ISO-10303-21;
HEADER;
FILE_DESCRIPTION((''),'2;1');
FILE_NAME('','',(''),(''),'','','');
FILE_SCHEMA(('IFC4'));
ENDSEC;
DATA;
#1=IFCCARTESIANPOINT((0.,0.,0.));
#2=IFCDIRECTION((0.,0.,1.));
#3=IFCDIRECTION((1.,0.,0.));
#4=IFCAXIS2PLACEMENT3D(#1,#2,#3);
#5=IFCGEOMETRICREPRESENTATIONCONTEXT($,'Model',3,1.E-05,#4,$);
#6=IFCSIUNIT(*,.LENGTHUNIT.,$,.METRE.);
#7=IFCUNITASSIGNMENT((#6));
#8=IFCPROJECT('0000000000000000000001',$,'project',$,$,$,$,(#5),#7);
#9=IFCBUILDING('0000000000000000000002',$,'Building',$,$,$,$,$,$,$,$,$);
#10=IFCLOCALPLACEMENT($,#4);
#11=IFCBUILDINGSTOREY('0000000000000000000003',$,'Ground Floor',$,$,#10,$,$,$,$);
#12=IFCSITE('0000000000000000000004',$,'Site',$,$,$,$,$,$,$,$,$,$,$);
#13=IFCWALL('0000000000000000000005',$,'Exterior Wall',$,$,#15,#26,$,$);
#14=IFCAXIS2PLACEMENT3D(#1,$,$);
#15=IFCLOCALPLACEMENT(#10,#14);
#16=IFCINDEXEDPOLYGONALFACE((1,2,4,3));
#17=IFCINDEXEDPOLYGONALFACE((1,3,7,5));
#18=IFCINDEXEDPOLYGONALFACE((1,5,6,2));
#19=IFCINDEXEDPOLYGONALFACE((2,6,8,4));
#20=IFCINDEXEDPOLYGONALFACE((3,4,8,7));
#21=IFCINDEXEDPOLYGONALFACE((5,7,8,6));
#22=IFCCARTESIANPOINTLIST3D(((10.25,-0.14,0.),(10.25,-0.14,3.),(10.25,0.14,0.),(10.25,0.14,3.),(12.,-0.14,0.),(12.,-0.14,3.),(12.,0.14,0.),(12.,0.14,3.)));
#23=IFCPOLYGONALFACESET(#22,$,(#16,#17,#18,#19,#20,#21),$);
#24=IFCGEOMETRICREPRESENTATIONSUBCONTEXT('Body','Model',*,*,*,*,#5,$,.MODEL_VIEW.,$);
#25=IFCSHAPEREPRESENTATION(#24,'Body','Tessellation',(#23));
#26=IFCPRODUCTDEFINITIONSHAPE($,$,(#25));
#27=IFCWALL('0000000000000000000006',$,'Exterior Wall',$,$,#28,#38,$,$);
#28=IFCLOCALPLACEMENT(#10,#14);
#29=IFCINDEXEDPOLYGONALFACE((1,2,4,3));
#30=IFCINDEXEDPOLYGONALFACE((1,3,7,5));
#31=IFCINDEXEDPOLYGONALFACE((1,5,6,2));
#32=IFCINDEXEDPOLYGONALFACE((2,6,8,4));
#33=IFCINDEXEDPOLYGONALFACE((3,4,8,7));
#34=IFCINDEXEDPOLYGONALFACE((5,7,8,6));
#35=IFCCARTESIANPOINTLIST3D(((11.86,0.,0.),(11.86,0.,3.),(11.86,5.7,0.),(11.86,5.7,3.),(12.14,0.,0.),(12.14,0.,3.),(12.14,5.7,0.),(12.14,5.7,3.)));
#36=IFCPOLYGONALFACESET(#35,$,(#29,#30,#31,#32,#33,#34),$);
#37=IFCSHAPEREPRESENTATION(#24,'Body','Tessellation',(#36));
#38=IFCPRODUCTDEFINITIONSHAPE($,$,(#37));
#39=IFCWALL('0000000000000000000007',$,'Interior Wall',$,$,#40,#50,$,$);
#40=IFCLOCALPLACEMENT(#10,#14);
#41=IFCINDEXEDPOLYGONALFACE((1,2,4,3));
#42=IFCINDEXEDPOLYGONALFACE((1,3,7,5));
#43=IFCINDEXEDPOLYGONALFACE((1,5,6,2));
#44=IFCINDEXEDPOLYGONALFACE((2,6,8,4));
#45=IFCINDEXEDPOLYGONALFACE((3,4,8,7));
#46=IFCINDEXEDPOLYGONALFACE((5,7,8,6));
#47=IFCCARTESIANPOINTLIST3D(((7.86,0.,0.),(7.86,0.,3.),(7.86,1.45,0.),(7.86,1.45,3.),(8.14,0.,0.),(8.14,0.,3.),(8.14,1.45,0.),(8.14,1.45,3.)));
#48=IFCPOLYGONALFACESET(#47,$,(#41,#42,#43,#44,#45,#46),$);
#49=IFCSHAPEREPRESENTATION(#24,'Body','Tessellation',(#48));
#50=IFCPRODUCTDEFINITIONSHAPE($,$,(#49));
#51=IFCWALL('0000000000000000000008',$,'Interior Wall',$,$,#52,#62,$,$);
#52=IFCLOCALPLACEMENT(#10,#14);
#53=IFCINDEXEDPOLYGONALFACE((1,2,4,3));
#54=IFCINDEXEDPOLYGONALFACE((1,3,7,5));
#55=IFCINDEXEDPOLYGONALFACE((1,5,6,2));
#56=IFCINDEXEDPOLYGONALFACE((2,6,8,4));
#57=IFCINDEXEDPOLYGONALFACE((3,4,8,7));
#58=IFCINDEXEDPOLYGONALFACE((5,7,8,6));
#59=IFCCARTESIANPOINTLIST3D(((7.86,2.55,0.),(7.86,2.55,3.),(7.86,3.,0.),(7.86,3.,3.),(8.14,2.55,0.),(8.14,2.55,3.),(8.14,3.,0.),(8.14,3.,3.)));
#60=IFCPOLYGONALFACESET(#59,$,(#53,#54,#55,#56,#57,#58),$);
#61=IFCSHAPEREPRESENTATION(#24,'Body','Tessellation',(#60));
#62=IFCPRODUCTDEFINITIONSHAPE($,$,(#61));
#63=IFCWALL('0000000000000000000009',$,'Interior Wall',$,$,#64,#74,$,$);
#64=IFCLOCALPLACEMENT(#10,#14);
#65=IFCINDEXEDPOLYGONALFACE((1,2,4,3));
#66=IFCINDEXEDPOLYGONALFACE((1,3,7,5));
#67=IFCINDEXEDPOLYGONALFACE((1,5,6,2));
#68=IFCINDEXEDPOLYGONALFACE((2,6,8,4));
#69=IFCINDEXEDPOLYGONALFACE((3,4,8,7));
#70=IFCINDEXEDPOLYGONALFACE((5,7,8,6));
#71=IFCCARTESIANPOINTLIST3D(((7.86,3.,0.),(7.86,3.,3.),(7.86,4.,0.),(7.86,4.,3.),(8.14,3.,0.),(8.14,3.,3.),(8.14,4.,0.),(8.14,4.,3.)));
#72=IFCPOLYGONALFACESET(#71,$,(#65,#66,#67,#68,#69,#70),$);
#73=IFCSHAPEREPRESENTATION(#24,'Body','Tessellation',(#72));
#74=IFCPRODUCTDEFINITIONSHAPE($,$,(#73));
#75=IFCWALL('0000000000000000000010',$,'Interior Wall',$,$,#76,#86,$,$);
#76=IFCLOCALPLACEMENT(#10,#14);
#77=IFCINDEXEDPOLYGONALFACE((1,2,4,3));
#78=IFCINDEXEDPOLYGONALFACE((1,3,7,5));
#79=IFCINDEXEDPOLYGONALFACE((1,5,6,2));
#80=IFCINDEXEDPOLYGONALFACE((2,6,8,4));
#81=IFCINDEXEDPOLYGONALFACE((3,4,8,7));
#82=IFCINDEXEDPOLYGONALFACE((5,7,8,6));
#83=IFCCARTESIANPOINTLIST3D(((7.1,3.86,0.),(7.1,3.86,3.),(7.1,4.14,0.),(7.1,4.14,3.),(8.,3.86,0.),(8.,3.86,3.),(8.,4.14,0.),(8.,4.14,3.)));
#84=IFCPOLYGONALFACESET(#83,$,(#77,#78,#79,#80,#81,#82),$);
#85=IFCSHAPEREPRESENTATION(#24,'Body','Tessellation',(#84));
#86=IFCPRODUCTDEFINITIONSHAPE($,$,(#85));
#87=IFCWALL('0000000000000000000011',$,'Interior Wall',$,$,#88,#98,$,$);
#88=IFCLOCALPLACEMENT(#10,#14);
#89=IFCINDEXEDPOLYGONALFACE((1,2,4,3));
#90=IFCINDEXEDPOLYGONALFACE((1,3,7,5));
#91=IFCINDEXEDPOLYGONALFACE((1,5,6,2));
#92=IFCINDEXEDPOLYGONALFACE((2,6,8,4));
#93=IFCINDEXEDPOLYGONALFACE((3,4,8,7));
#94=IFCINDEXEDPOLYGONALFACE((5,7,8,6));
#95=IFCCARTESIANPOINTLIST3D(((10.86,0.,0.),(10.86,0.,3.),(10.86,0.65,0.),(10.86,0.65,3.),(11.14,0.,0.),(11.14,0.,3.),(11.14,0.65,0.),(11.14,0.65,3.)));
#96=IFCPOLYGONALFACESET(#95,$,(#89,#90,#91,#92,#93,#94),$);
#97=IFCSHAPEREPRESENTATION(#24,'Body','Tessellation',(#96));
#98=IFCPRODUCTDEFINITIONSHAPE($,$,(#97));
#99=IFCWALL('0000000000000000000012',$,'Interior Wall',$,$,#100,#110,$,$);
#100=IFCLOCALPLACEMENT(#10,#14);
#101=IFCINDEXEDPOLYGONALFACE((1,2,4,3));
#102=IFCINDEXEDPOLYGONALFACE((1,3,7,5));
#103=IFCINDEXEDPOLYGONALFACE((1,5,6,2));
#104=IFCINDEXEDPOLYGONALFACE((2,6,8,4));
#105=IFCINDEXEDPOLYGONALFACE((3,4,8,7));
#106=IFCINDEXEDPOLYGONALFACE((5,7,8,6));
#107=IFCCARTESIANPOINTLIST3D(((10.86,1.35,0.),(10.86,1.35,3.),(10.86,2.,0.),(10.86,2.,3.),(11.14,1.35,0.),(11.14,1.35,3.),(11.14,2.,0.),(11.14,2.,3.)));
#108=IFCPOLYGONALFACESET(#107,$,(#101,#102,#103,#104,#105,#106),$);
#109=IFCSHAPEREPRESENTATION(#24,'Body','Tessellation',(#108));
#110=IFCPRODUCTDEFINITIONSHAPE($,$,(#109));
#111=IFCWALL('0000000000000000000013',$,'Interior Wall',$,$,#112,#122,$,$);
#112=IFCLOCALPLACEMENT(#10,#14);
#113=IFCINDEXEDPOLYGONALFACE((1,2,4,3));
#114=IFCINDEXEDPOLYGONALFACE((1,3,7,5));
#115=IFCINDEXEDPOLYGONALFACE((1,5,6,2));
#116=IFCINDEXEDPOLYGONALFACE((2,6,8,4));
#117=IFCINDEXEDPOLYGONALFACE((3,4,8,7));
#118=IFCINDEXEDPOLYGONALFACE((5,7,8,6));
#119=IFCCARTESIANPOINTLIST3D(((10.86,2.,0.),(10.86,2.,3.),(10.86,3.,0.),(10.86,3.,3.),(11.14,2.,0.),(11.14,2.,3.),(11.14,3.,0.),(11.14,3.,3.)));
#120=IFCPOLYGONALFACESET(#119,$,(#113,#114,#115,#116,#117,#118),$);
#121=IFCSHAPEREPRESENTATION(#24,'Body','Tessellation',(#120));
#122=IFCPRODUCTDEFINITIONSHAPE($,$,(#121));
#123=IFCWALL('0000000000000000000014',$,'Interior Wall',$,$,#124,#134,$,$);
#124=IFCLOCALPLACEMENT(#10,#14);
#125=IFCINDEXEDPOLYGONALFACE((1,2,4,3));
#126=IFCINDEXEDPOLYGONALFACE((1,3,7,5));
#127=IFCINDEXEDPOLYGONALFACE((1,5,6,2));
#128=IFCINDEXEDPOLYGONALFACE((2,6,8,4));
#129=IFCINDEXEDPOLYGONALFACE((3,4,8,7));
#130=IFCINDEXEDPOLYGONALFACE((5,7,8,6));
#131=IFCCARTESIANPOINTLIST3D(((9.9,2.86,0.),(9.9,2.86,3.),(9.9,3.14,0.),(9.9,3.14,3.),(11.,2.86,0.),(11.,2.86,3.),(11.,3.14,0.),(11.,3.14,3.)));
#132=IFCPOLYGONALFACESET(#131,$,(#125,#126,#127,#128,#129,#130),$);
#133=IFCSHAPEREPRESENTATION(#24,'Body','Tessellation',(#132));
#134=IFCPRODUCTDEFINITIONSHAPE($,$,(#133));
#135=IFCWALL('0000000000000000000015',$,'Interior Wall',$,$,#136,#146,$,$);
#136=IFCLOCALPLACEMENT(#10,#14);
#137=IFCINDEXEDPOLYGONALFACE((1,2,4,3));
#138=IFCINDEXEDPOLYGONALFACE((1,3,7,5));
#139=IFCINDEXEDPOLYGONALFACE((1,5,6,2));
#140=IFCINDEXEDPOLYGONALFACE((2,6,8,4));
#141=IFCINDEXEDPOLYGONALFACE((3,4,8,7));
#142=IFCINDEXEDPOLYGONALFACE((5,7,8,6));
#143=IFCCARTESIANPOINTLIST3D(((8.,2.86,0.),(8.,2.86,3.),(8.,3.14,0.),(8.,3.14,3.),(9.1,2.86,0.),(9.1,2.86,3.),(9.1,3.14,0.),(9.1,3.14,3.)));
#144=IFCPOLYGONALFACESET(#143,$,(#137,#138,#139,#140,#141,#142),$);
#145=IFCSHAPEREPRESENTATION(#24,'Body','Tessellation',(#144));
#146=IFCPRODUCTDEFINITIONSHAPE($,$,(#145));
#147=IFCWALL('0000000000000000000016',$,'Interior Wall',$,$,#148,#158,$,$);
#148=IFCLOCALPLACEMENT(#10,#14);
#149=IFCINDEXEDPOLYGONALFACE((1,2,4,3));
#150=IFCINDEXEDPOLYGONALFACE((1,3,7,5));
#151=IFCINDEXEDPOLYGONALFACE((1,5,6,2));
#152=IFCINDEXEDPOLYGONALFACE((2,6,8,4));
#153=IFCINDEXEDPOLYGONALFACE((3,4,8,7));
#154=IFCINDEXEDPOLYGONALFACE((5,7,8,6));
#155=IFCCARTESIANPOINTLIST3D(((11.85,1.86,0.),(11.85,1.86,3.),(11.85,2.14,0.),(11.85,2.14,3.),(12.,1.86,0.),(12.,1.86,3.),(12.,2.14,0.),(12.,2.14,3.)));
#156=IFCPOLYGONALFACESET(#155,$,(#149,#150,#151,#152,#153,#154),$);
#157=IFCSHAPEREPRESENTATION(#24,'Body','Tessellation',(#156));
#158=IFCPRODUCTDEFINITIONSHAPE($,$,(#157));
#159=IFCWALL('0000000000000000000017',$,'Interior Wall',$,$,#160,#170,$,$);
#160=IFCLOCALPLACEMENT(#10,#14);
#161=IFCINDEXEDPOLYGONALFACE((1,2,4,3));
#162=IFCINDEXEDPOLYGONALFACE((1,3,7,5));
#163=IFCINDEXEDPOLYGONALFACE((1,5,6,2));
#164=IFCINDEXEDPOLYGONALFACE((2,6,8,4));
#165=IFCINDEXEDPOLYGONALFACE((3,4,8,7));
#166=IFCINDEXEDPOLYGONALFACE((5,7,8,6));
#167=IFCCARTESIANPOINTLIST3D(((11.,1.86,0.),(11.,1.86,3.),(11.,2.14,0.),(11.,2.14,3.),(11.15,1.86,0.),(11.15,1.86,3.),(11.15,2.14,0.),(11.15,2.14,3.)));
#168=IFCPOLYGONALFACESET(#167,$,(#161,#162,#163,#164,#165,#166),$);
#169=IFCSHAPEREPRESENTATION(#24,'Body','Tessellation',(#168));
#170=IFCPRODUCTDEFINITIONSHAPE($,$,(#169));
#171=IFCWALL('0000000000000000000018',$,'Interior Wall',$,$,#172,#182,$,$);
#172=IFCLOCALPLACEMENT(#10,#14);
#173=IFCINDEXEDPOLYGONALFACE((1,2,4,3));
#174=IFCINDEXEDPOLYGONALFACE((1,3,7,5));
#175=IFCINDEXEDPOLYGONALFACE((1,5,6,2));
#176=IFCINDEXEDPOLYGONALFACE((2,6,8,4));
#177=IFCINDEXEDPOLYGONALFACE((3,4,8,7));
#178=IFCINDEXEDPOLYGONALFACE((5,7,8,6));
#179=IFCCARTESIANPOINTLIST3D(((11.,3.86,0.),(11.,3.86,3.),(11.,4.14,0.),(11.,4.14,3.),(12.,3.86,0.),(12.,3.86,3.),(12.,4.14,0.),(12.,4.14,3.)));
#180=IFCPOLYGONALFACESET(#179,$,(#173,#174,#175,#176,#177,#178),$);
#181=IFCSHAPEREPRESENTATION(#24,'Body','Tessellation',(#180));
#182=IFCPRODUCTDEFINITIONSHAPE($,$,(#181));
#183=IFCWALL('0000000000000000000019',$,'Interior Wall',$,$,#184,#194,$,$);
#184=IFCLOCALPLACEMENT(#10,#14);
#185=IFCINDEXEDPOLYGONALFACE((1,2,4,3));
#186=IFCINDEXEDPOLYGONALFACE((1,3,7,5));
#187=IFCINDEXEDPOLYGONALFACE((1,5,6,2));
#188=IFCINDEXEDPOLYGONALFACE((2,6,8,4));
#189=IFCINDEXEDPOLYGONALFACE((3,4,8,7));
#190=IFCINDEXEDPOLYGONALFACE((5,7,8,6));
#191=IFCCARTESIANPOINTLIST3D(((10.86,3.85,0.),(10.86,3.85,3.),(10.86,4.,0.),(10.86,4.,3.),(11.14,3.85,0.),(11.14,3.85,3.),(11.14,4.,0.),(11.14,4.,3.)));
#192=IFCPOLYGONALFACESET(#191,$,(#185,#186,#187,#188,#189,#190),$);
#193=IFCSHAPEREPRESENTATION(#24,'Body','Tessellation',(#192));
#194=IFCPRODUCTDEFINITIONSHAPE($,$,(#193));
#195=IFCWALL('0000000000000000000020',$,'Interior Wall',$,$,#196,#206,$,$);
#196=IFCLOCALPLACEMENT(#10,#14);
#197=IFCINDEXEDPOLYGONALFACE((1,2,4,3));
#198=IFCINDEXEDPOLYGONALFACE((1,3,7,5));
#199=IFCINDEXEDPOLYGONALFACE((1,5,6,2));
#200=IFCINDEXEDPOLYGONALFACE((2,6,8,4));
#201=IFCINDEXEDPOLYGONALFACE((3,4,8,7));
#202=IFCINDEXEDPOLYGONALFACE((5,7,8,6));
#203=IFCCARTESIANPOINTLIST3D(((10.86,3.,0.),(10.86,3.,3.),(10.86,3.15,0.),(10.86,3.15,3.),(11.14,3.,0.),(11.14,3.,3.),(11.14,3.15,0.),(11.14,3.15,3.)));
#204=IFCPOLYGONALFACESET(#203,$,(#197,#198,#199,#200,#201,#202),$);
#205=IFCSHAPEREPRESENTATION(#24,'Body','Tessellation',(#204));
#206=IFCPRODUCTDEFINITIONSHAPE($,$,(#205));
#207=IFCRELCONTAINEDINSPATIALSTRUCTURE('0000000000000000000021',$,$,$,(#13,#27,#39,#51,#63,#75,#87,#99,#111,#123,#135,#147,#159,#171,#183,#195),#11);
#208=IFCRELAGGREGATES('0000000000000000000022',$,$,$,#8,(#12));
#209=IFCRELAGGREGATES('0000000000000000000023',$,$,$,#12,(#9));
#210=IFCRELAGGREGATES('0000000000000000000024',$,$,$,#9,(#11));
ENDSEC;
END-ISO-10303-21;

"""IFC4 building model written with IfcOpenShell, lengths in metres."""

from ifc_helpers import new_model, si_unit, frame, origin_with_axes, place, context, subcontext, project, spatial, indexed_curve, outline, extrude, element, save


model = new_model("IFC4")

# Units and contexts
model_context = context("Model", 3, precision=1e-05, world=origin_with_axes())
body_context = subcontext(model_context, "Body", "Model", "MODEL_VIEW")
ifc_project = project(units=[si_unit("LENGTHUNIT", "METRE")], contexts=[model_context])

# Site, building, storey
site = spatial("IfcSite", under=ifc_project, Name="Site")
building = spatial("IfcBuilding", under=site, Name="Building")
storey_placement = place(None, origin_with_axes())
storey = spatial("IfcBuildingStorey", under=building, at=storey_placement, Name="Ground Floor")

# Walls
wall_1_placement = place(storey_placement, frame((10.25, 0.0, 0.0), z_axis=(0.0, 0.0, 1.0), x_axis=(1.0, 0.0, 0.0)))
element("IfcWall", 1, at=wall_1_placement, inside=storey, Name="Exterior Wall", context=body_context, shape_type="SweptSolid", body=[
    extrude(outline(indexed_curve([(0.0, 0.0), (0.0, 0.28), (1.75, 0.28), (1.75, 0.0), (0.0, 0.0)], self_intersect=False)), frame((0.0, -0.14, 0.0), z_axis=(0.0, 0.0, 1.0), x_axis=(1.0, 0.0, 0.0)), (0.0, 0.0, 1.0), 3.0),
])
wall_2_placement = place(storey_placement, frame((12.0, 0.0, 0.0), z_axis=(0.0, 0.0, 1.0), x_axis=(0.0, 1.0, 0.0)))
element("IfcWall", 2, at=wall_2_placement, inside=storey, Name="Exterior Wall", context=body_context, shape_type="SweptSolid", body=[
    extrude(outline(indexed_curve([(0.0, 0.0), (0.0, 0.28), (5.7, 0.28), (5.7, 0.0), (0.0, 0.0)], self_intersect=False)), frame((0.0, -0.14, 0.0), z_axis=(0.0, 0.0, 1.0), x_axis=(1.0, 0.0, 0.0)), (0.0, 0.0, 1.0), 3.0),
])
wall_3_placement = place(storey_placement, frame((8.0, 0.0, 0.0), z_axis=(0.0, 0.0, 1.0), x_axis=(0.0, 1.0, 0.0)))
element("IfcWall", 3, at=wall_3_placement, inside=storey, Name="Interior Wall", context=body_context, shape_type="SweptSolid", body=[
    extrude(outline(indexed_curve([(0.0, 0.0), (0.0, 0.28), (1.45, 0.28), (1.45, 0.0), (0.0, 0.0)], self_intersect=False)), frame((0.0, -0.14, 0.0), z_axis=(0.0, 0.0, 1.0), x_axis=(1.0, 0.0, 0.0)), (0.0, 0.0, 1.0), 3.0),
])
wall_4_placement = place(storey_placement, frame((8.0, 2.55, 0.0), z_axis=(0.0, 0.0, 1.0), x_axis=(0.0, 1.0, 0.0)))
element("IfcWall", 4, at=wall_4_placement, inside=storey, Name="Interior Wall", context=body_context, shape_type="SweptSolid", body=[
    extrude(outline(indexed_curve([(0.0, 0.0), (0.0, 0.28), (0.45, 0.28), (0.45, 0.0), (0.0, 0.0)], self_intersect=False)), frame((0.0, -0.14, 0.0), z_axis=(0.0, 0.0, 1.0), x_axis=(1.0, 0.0, 0.0)), (0.0, 0.0, 1.0), 3.0),
])
wall_5_placement = place(storey_placement, frame((8.0, 3.0, 0.0), z_axis=(0.0, 0.0, 1.0), x_axis=(0.0, 1.0, 0.0)))
element("IfcWall", 5, at=wall_5_placement, inside=storey, Name="Interior Wall", context=body_context, shape_type="SweptSolid", body=[
    extrude(outline(indexed_curve([(0.0, 0.0), (0.0, 0.28), (1.0, 0.28), (1.0, 0.0), (0.0, 0.0)], self_intersect=False)), frame((0.0, -0.14, 0.0), z_axis=(0.0, 0.0, 1.0), x_axis=(1.0, 0.0, 0.0)), (0.0, 0.0, 1.0), 3.0),
])
wall_6_placement = place(storey_placement, frame((8.0, 4.0, 0.0), z_axis=(0.0, 0.0, 1.0), x_axis=(-1.0, 0.0, 0.0)))
element("IfcWall", 6, at=wall_6_placement, inside=storey, Name="Interior Wall", context=body_context, shape_type="SweptSolid", body=[
    extrude(outline(indexed_curve([(0.0, 0.0), (0.0, 0.28), (0.9, 0.28), (0.9, 0.0), (0.0, 0.0)], self_intersect=False)), frame((0.0, -0.14, 0.0), z_axis=(0.0, 0.0, 1.0), x_axis=(1.0, 0.0, 0.0)), (0.0, 0.0, 1.0), 3.0),
])
wall_7_placement = place(storey_placement, frame((11.0, 0.0, 0.0), z_axis=(0.0, 0.0, 1.0), x_axis=(0.0, 1.0, 0.0)))
element("IfcWall", 7, at=wall_7_placement, inside=storey, Name="Interior Wall", context=body_context, shape_type="SweptSolid", body=[
    extrude(outline(indexed_curve([(0.0, 0.0), (0.0, 0.28), (0.65, 0.28), (0.65, 0.0), (0.0, 0.0)], self_intersect=False)), frame((0.0, -0.14, 0.0), z_axis=(0.0, 0.0, 1.0), x_axis=(1.0, 0.0, 0.0)), (0.0, 0.0, 1.0), 3.0),
])
wall_8_placement = place(storey_placement, frame((11.0, 1.35, 0.0), z_axis=(0.0, 0.0, 1.0), x_axis=(0.0, 1.0, 0.0)))
element("IfcWall", 8, at=wall_8_placement, inside=storey, Name="Interior Wall", context=body_context, shape_type="SweptSolid", body=[
    extrude(outline(indexed_curve([(0.0, 0.0), (0.0, 0.28), (0.65, 0.28), (0.65, 0.0), (0.0, 0.0)], self_intersect=False)), frame((0.0, -0.14, 0.0), z_axis=(0.0, 0.0, 1.0), x_axis=(1.0, 0.0, 0.0)), (0.0, 0.0, 1.0), 3.0),
])
wall_9_placement = place(storey_placement, frame((11.0, 2.0, 0.0), z_axis=(0.0, 0.0, 1.0), x_axis=(0.0, 1.0, 0.0)))
element("IfcWall", 9, at=wall_9_placement, inside=storey, Name="Interior Wall", context=body_context, shape_type="SweptSolid", body=[
    extrude(outline(indexed_curve([(0.0, 0.0), (0.0, 0.28), (1.0, 0.28), (1.0, 0.0), (0.0, 0.0)], self_intersect=False)), frame((0.0, -0.14, 0.0), z_axis=(0.0, 0.0, 1.0), x_axis=(1.0, 0.0, 0.0)), (0.0, 0.0, 1.0), 3.0),
])
for number, where, z_axis, x_axis, name in (
    (10, (11.0, 3.0, 0.0), (0.0, 0.0, 1.0), (-1.0, 0.0, 0.0), "Interior Wall"),
    (11, (9.1, 3.0, 0.0), (0.0, 0.0, 1.0), (-1.0, 0.0, 0.0), "Interior Wall"),
):
    element("IfcWall", number, at=place(storey_placement, frame(where, z_axis=z_axis, x_axis=x_axis)), inside=storey, Name=name, context=body_context, shape_type="SweptSolid", body=[
        extrude(outline(indexed_curve([(0.0, 0.0), (0.0, 0.28), (1.1, 0.28), (1.1, 0.0), (0.0, 0.0)], self_intersect=False)), frame((0.0, -0.14, 0.0), z_axis=(0.0, 0.0, 1.0), x_axis=(1.0, 0.0, 0.0)), (0.0, 0.0, 1.0), 3.0),
    ])
for number, where, z_axis, x_axis, name in (
    (12, (12.0, 2.0, 0.0), (0.0, 0.0, 1.0), (-1.0, 0.0, 0.0), "Interior Wall"),
    (13, (11.15, 2.0, 0.0), (0.0, 0.0, 1.0), (-1.0, 0.0, 0.0), "Interior Wall"),
):
    element("IfcWall", number, at=place(storey_placement, frame(where, z_axis=z_axis, x_axis=x_axis)), inside=storey, Name=name, context=body_context, shape_type="SweptSolid", body=[
        extrude(outline(indexed_curve([(0.0, 0.0), (0.0, 0.28), (0.15, 0.28), (0.15, 0.0), (0.0, 0.0)], self_intersect=False)), frame((0.0, -0.14, 0.0), z_axis=(0.0, 0.0, 1.0), x_axis=(1.0, 0.0, 0.0)), (0.0, 0.0, 1.0), 3.0),
    ])
wall_10_placement = place(storey_placement, frame((12.0, 4.0, 0.0), z_axis=(0.0, 0.0, 1.0), x_axis=(-1.0, 0.0, 0.0)))
element("IfcWall", 14, at=wall_10_placement, inside=storey, Name="Interior Wall", context=body_context, shape_type="SweptSolid", body=[
    extrude(outline(indexed_curve([(0.0, 0.0), (0.0, 0.28), (1.0, 0.28), (1.0, 0.0), (0.0, 0.0)], self_intersect=False)), frame((0.0, -0.14, 0.0), z_axis=(0.0, 0.0, 1.0), x_axis=(1.0, 0.0, 0.0)), (0.0, 0.0, 1.0), 3.0),
])
for number, where, z_axis, x_axis, name in (
    (15, (11.0, 4.0, 0.0), (0.0, 0.0, 1.0), (0.0, -1.0, 0.0), "Interior Wall"),
    (16, (11.0, 3.15, 0.0), (0.0, 0.0, 1.0), (0.0, -1.0, 0.0), "Interior Wall"),
):
    element("IfcWall", number, at=place(storey_placement, frame(where, z_axis=z_axis, x_axis=x_axis)), inside=storey, Name=name, context=body_context, shape_type="SweptSolid", body=[
        extrude(outline(indexed_curve([(0.0, 0.0), (0.0, 0.28), (0.15, 0.28), (0.15, 0.0), (0.0, 0.0)], self_intersect=False)), frame((0.0, -0.14, 0.0), z_axis=(0.0, 0.0, 1.0), x_axis=(1.0, 0.0, 0.0)), (0.0, 0.0, 1.0), 3.0),
    ])

save(model, "model.ifc")
